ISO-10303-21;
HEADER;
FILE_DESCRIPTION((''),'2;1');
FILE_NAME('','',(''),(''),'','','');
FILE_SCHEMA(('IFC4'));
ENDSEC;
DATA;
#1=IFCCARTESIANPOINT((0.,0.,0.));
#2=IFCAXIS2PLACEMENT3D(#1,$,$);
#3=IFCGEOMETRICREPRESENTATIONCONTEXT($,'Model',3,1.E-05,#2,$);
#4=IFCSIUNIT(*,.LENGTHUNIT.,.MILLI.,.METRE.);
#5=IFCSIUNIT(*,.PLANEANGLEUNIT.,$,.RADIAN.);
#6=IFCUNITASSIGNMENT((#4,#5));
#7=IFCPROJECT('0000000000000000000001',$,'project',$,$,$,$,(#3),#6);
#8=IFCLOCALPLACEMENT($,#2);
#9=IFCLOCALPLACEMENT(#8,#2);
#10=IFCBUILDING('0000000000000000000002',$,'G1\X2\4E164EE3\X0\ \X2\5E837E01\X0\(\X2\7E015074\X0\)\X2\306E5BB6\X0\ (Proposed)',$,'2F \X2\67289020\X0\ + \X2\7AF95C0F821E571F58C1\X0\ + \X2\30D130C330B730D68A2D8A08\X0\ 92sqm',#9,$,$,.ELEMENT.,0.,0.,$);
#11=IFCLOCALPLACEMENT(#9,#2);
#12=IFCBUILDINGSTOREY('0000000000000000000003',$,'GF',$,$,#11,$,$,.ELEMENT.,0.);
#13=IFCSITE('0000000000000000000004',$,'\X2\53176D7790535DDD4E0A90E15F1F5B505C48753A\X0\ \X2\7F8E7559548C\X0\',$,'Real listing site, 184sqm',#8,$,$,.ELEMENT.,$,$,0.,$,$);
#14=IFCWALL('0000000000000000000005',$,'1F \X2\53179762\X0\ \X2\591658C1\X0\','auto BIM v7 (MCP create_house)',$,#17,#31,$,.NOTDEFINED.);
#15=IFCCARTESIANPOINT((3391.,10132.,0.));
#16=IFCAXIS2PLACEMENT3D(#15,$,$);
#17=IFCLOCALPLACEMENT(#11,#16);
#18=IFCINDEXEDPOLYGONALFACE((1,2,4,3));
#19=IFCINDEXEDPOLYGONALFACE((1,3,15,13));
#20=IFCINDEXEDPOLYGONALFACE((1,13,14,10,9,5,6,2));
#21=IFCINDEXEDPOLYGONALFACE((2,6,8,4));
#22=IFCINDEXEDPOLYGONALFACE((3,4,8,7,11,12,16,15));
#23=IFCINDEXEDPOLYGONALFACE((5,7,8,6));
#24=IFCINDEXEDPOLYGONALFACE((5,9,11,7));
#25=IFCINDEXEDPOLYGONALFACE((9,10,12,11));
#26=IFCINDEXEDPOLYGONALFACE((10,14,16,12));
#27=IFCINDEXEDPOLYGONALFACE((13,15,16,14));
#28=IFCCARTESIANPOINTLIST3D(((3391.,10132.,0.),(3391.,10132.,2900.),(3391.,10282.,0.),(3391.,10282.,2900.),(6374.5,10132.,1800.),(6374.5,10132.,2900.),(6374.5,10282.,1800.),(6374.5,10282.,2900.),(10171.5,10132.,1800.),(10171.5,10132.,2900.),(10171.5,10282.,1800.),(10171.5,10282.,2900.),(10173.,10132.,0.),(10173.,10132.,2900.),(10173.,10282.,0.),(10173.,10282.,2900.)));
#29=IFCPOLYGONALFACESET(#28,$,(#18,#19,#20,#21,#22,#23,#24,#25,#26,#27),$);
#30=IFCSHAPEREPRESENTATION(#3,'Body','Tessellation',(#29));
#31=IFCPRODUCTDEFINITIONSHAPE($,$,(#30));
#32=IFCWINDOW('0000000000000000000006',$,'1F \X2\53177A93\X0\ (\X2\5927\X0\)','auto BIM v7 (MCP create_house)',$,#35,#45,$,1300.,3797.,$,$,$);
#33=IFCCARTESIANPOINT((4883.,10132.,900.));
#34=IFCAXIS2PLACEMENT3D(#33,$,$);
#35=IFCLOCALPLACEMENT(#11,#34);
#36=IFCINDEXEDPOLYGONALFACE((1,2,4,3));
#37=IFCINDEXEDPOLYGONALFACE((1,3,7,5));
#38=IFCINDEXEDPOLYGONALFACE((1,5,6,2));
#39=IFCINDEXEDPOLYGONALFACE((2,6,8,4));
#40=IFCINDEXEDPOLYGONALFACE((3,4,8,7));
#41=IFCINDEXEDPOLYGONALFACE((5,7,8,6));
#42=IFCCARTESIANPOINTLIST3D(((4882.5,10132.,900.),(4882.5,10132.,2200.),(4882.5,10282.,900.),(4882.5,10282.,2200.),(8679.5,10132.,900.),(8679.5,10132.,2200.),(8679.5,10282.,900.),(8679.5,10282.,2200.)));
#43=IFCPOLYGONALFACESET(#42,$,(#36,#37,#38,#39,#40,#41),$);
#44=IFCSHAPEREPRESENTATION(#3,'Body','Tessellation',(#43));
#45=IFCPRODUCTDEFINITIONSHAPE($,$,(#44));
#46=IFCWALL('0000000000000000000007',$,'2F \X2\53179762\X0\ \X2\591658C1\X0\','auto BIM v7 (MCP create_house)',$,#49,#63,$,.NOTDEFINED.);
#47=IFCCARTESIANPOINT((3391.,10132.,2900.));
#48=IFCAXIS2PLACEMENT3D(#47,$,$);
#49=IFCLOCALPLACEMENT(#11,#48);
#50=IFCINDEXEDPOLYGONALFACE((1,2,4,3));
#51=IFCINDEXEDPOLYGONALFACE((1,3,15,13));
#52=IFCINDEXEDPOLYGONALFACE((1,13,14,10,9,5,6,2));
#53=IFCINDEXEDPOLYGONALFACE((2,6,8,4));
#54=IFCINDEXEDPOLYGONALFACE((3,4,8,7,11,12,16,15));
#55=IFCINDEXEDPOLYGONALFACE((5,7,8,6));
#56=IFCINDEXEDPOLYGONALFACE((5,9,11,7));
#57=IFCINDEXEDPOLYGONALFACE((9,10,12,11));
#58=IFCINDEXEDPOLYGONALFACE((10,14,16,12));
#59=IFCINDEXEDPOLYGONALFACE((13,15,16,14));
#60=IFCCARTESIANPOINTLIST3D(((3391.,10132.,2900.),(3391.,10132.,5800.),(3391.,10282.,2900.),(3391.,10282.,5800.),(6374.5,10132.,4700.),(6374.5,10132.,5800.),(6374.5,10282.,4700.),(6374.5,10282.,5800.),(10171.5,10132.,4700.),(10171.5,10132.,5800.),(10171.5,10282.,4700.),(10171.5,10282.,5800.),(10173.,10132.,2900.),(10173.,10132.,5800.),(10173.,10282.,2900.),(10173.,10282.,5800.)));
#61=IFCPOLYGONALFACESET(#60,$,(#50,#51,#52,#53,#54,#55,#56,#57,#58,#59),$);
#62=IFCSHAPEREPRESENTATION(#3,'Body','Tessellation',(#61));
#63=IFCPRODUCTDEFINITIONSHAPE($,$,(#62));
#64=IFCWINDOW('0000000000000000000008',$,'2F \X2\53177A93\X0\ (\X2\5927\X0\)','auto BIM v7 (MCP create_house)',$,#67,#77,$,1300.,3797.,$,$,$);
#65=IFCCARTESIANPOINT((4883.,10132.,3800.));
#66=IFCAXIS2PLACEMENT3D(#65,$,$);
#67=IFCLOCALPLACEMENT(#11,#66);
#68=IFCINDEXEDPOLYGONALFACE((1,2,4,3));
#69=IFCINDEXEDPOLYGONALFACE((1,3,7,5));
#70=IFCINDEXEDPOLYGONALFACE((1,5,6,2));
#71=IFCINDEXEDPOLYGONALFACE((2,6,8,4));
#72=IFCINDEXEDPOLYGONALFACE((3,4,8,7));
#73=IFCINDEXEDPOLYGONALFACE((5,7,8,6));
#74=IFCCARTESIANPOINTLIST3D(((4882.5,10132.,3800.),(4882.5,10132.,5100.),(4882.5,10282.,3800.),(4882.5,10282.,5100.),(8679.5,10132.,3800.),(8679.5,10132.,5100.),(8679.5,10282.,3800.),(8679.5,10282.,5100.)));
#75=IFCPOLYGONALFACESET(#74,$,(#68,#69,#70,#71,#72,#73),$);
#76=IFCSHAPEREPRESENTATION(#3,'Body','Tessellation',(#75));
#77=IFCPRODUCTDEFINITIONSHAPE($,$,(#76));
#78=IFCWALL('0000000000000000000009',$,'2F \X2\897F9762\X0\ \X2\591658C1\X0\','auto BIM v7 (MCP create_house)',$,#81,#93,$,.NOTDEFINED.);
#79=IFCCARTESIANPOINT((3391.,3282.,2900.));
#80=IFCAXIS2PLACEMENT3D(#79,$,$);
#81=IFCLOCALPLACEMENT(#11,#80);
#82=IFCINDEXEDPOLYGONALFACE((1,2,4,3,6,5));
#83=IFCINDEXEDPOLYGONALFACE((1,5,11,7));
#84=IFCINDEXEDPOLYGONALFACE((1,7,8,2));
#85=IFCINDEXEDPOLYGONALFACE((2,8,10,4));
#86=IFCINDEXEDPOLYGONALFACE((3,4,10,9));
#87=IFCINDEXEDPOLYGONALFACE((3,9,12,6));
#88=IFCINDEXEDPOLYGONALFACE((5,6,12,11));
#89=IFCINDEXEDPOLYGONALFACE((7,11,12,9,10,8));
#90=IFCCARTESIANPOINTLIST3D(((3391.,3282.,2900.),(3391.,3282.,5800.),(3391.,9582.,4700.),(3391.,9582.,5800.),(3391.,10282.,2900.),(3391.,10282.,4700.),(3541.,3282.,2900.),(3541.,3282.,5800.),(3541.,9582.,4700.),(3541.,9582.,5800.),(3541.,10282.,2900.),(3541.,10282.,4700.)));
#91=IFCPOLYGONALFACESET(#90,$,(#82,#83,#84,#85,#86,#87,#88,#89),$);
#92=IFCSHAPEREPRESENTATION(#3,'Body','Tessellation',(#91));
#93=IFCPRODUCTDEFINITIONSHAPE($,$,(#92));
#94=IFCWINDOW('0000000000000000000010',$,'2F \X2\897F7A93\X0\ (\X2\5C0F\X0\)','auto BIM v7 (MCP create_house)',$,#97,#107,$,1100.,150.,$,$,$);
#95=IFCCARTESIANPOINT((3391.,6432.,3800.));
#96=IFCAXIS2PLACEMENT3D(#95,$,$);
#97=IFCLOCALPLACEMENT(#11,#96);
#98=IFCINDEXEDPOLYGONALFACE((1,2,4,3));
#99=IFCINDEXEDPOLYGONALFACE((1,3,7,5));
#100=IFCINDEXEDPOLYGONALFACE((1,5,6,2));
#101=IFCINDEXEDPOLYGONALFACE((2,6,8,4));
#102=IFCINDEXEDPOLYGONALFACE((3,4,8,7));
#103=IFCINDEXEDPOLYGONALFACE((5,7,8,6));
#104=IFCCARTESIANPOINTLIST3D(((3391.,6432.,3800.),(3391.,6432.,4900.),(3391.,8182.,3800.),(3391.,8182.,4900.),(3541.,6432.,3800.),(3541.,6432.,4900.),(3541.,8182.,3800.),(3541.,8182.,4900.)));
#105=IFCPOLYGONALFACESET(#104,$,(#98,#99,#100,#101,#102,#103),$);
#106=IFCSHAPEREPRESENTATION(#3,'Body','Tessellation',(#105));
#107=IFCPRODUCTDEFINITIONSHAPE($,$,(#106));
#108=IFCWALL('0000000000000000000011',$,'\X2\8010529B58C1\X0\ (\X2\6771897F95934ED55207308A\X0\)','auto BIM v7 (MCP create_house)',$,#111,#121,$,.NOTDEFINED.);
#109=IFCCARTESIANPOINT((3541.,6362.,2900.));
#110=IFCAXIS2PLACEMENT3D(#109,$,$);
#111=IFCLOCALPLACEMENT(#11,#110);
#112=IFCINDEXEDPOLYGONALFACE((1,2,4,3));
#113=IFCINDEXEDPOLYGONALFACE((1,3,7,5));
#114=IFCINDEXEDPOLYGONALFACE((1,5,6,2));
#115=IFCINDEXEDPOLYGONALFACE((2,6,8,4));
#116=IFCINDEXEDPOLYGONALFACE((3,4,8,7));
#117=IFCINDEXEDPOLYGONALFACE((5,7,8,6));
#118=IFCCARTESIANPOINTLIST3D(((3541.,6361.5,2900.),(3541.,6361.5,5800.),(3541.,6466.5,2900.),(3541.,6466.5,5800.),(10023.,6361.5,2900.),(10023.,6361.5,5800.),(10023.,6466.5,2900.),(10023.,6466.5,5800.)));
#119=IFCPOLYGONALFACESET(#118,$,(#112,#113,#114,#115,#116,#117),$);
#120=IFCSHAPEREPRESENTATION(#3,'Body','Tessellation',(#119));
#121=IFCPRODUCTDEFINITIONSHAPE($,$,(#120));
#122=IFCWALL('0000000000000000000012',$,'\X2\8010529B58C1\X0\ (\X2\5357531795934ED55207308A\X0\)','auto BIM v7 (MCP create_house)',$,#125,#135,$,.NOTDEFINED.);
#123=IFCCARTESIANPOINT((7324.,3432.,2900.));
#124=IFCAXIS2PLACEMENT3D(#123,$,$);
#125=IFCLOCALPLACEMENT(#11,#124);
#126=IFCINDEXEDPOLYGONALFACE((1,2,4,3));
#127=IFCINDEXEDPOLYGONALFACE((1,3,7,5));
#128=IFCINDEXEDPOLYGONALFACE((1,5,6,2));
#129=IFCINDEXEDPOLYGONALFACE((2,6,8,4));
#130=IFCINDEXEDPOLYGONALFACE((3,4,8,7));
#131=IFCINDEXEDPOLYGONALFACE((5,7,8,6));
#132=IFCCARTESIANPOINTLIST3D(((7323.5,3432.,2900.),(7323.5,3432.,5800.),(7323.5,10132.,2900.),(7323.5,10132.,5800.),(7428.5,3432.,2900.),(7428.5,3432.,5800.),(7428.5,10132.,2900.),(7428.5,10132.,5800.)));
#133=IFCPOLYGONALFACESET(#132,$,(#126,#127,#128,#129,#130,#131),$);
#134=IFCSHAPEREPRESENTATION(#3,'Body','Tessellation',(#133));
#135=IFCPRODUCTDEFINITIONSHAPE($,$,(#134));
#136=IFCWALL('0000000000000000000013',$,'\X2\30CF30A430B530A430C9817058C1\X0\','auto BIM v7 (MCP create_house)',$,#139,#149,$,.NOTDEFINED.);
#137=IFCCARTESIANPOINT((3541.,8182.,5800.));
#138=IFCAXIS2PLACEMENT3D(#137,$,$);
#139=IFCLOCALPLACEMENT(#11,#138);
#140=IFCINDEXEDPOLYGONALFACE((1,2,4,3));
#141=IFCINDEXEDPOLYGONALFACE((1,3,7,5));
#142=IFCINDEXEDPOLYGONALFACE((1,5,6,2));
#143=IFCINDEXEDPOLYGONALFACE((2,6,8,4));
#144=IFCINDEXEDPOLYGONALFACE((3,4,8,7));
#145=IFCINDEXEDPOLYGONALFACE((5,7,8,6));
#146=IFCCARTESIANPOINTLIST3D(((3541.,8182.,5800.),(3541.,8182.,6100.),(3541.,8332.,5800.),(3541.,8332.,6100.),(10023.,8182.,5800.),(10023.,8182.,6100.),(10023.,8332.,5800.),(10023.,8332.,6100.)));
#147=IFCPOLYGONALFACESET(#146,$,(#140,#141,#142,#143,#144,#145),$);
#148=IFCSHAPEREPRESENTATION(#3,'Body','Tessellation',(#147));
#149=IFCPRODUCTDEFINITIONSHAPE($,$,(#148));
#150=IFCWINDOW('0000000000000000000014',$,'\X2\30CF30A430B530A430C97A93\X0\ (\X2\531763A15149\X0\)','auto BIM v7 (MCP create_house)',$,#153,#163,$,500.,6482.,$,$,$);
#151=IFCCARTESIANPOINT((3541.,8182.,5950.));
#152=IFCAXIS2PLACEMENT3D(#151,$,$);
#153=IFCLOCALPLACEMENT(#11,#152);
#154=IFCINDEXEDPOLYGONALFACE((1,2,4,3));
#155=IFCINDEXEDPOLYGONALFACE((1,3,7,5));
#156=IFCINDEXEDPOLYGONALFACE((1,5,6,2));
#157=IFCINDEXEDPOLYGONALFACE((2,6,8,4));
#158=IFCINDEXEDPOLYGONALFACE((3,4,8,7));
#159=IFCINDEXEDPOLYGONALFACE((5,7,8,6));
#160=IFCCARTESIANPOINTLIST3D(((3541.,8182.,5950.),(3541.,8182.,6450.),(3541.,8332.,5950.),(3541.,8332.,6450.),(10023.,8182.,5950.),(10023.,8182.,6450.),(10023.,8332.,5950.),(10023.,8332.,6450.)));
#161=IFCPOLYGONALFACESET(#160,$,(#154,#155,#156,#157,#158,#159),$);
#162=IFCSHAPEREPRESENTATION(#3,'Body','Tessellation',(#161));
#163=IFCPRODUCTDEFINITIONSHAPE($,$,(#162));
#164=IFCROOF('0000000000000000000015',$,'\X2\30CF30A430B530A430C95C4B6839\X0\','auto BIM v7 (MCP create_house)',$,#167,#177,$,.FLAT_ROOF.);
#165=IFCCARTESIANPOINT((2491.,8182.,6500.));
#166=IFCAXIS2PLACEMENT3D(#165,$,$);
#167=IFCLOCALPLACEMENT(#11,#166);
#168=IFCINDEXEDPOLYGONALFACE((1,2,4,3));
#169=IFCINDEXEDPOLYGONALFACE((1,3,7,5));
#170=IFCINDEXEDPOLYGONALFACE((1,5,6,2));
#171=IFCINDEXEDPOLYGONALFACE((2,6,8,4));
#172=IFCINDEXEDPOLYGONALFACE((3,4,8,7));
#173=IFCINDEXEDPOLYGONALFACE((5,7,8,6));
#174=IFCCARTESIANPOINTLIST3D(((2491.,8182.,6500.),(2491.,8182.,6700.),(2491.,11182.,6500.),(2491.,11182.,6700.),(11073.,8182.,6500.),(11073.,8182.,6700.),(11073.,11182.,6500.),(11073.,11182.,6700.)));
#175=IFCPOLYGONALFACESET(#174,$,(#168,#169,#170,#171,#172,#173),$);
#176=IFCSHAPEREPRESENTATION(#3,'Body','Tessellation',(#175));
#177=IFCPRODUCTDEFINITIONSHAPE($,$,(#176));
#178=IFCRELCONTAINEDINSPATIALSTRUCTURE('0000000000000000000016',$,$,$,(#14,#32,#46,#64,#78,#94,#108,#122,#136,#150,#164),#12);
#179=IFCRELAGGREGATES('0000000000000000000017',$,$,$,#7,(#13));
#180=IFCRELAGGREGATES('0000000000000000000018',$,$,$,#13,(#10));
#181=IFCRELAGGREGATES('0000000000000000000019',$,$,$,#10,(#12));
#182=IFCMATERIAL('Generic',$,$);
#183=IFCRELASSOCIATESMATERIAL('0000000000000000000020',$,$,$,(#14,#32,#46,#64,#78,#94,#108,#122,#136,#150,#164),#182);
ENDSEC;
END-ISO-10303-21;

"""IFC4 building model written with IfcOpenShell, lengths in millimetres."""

from ifc_helpers import new_model, si_unit, frame, frame_2d, origin, place, context, project, spatial, rectangle, extrude, material, element, fill, save


model = new_model("IFC4")

# Units and contexts
model_context = context("Model", 3, precision=1e-05, world=origin())
ifc_project = project(units=[si_unit("LENGTHUNIT", "METRE", prefix="MILLI"), si_unit("PLANEANGLEUNIT", "RADIAN")], contexts=[model_context])

# Site, building, storey
site_placement = place(None, origin())
site = spatial("IfcSite", under=ifc_project, at=site_placement, Name="北海道川上郡弟子屈町 美留和", ObjectType="Real listing site, 184sqm", CompositionType="ELEMENT", RefElevation=0.0)
building_placement = place(site_placement, origin())
building = spatial("IfcBuilding", under=site, at=building_placement, Name="G1世代 広縁(縁側)の家 (Proposed)", ObjectType="2F 木造 + 竹小舞土壁 + パッシブ設計 92sqm", CompositionType="ELEMENT", ElevationOfRefHeight=0.0, ElevationOfTerrain=0.0)
storey_placement = place(building_placement, origin())
storey = spatial("IfcBuildingStorey", under=building, at=storey_placement, Name="GF", CompositionType="ELEMENT", Elevation=0.0)

# Wall, opening, window
ifc_material = material(Name="Generic")
wall_1_placement = place(storey_placement, frame((3391.0, 10132.0, 0.0)))
wall_1 = element("IfcWall", 1, at=wall_1_placement, inside=storey, material=ifc_material, Name="1F 北面 外壁", Description="auto BIM v7 (MCP create_house)", PredefinedType="NOTDEFINED", context=model_context, shape_type="SweptSolid", body=[
    extrude(rectangle(XDim=6782.0, YDim=150.0, at=frame_2d((3391.0, 75.0))), frame((3391.0, 10132.0, 0.0)), (0.0, 0.0, 1.0), 2900.0),
])
opening_1_placement = place(storey_placement, frame((4883.0, 10132.0, 900.0)))
opening_1 = element("IfcOpeningElement", 2, at=opening_1_placement, cuts=wall_1, PredefinedType="NOTDEFINED", context=model_context, shape_type="SweptSolid", body=[
    extrude(rectangle(XDim=3797.0, YDim=150.0, at=frame_2d((1898.0, 75.0))), frame((4883.0, 10132.0, 900.0)), (0.0, 0.0, 1.0), 1300.0),
])
window_1_placement = place(storey_placement, frame((4883.0, 10132.0, 900.0)))
window_1 = element("IfcWindow", 3, at=window_1_placement, inside=storey, material=ifc_material, Name="1F 北窓 (大)", Description="auto BIM v7 (MCP create_house)", OverallHeight=1300.0, OverallWidth=3797.0, context=model_context, shape_type="SweptSolid", body=[
    extrude(rectangle(XDim=3797.0, YDim=150.0, at=frame_2d((1898.0, 75.0))), frame((4883.0, 10132.0, 900.0)), (0.0, 0.0, 1.0), 1300.0),
])
fill(opening_1, window_1)

# Walls, openings, windows
wall_2_placement = place(storey_placement, frame((3391.0, 10132.0, 2900.0)))
wall_2 = element("IfcWall", 4, at=wall_2_placement, inside=storey, material=ifc_material, Name="2F 北面 外壁", Description="auto BIM v7 (MCP create_house)", PredefinedType="NOTDEFINED", context=model_context, shape_type="SweptSolid", body=[
    extrude(rectangle(XDim=6782.0, YDim=150.0, at=frame_2d((3391.0, 75.0))), frame((3391.0, 10132.0, 2900.0)), (0.0, 0.0, 1.0), 2900.0),
])
opening_2_placement = place(storey_placement, frame((4883.0, 10132.0, 3800.0)))
opening_2 = element("IfcOpeningElement", 5, at=opening_2_placement, cuts=wall_2, PredefinedType="NOTDEFINED", context=model_context, shape_type="SweptSolid", body=[
    extrude(rectangle(XDim=3797.0, YDim=150.0, at=frame_2d((1898.0, 75.0))), frame((4883.0, 10132.0, 3800.0)), (0.0, 0.0, 1.0), 1300.0),
])
window_2_placement = place(storey_placement, frame((4883.0, 10132.0, 3800.0)))
window_2 = element("IfcWindow", 6, at=window_2_placement, inside=storey, material=ifc_material, Name="2F 北窓 (大)", Description="auto BIM v7 (MCP create_house)", OverallHeight=1300.0, OverallWidth=3797.0, context=model_context, shape_type="SweptSolid", body=[
    extrude(rectangle(XDim=3797.0, YDim=150.0, at=frame_2d((1898.0, 75.0))), frame((4883.0, 10132.0, 3800.0)), (0.0, 0.0, 1.0), 1300.0),
])
fill(opening_2, window_2)
wall_3_placement = place(storey_placement, frame((3391.0, 3282.0, 2900.0)))
wall_3 = element("IfcWall", 7, at=wall_3_placement, inside=storey, material=ifc_material, Name="2F 西面 外壁", Description="auto BIM v7 (MCP create_house)", PredefinedType="NOTDEFINED", context=model_context, shape_type="SweptSolid", body=[
    extrude(rectangle(XDim=150.0, YDim=7000.0, at=frame_2d((75.0, 3500.0))), frame((3391.0, 3282.0, 2900.0)), (0.0, 0.0, 1.0), 2900.0),
])
opening_3_placement = place(storey_placement, frame((3391.0, 6432.0, 3800.0)))
opening_3 = element("IfcOpeningElement", 8, at=opening_3_placement, cuts=wall_3, PredefinedType="NOTDEFINED", context=model_context, shape_type="SweptSolid", body=[
    extrude(rectangle(XDim=150.0, YDim=1750.0, at=frame_2d((75.0, 875.0))), frame((3391.0, 6432.0, 3800.0)), (0.0, 0.0, 1.0), 1100.0),
])
window_3_placement = place(storey_placement, frame((3391.0, 6432.0, 3800.0)))
window_3 = element("IfcWindow", 9, at=window_3_placement, inside=storey, material=ifc_material, Name="2F 西窓 (小)", Description="auto BIM v7 (MCP create_house)", OverallHeight=1100.0, OverallWidth=150.0, context=model_context, shape_type="SweptSolid", body=[
    extrude(rectangle(XDim=150.0, YDim=1750.0, at=frame_2d((75.0, 875.0))), frame((3391.0, 6432.0, 3800.0)), (0.0, 0.0, 1.0), 1100.0),
])
fill(opening_3, window_3)

# Walls
wall_4_placement = place(storey_placement, frame((3541.0, 6362.0, 2900.0)))
element("IfcWall", 10, at=wall_4_placement, inside=storey, material=ifc_material, Name="耐力壁 (東西間仕切り)", Description="auto BIM v7 (MCP create_house)", PredefinedType="NOTDEFINED", context=model_context, shape_type="SweptSolid", body=[
    extrude(rectangle(XDim=6482.0, YDim=105.0, at=frame_2d((3241.0, 52.0))), frame((3541.0, 6362.0, 2900.0)), (0.0, 0.0, 1.0), 2900.0),
])
wall_5_placement = place(storey_placement, frame((7324.0, 3432.0, 2900.0)))
element("IfcWall", 11, at=wall_5_placement, inside=storey, material=ifc_material, Name="耐力壁 (南北間仕切り)", Description="auto BIM v7 (MCP create_house)", PredefinedType="NOTDEFINED", context=model_context, shape_type="SweptSolid", body=[
    extrude(rectangle(XDim=105.0, YDim=6700.0, at=frame_2d((52.0, 3350.0))), frame((7324.0, 3432.0, 2900.0)), (0.0, 0.0, 1.0), 2900.0),
])

# Wall, opening, window
wall_6_placement = place(storey_placement, frame((3541.0, 8182.0, 5800.0)))
wall_6 = element("IfcWall", 12, at=wall_6_placement, inside=storey, material=ifc_material, Name="ハイサイド腰壁", Description="auto BIM v7 (MCP create_house)", PredefinedType="NOTDEFINED", context=model_context, shape_type="SweptSolid", body=[
    extrude(rectangle(XDim=6482.0, YDim=150.0, at=frame_2d((3241.0, 75.0))), frame((3541.0, 8182.0, 5800.0)), (0.0, 0.0, 1.0), 700.0),
])
opening_4_placement = place(storey_placement, frame((3541.0, 8182.0, 5950.0)))
opening_4 = element("IfcOpeningElement", 13, at=opening_4_placement, cuts=wall_6, PredefinedType="NOTDEFINED", context=model_context, shape_type="SweptSolid", body=[
    extrude(rectangle(XDim=6482.0, YDim=150.0, at=frame_2d((3241.0, 75.0))), frame((3541.0, 8182.0, 5950.0)), (0.0, 0.0, 1.0), 500.0),
])
window_4_placement = place(storey_placement, frame((3541.0, 8182.0, 5950.0)))
window_4 = element("IfcWindow", 14, at=window_4_placement, inside=storey, material=ifc_material, Name="ハイサイド窓 (北採光)", Description="auto BIM v7 (MCP create_house)", OverallHeight=500.0, OverallWidth=6482.0, context=model_context, shape_type="SweptSolid", body=[
    extrude(rectangle(XDim=6482.0, YDim=150.0, at=frame_2d((3241.0, 75.0))), frame((3541.0, 8182.0, 5950.0)), (0.0, 0.0, 1.0), 500.0),
])
fill(opening_4, window_4)

# Roof
roof_placement = place(storey_placement, frame((2491.0, 8182.0, 6500.0)))
element("IfcRoof", 15, at=roof_placement, inside=storey, material=ifc_material, Name="ハイサイド屋根", Description="auto BIM v7 (MCP create_house)", PredefinedType="FLAT_ROOF", context=model_context, shape_type="SweptSolid", body=[
    extrude(rectangle(XDim=8582.0, YDim=3000.0, at=frame_2d((4291.0, 1500.0))), frame((2491.0, 8182.0, 6500.0)), (0.0, 0.0, 1.0), 200.0),
])

save(model, "model.ifc")
